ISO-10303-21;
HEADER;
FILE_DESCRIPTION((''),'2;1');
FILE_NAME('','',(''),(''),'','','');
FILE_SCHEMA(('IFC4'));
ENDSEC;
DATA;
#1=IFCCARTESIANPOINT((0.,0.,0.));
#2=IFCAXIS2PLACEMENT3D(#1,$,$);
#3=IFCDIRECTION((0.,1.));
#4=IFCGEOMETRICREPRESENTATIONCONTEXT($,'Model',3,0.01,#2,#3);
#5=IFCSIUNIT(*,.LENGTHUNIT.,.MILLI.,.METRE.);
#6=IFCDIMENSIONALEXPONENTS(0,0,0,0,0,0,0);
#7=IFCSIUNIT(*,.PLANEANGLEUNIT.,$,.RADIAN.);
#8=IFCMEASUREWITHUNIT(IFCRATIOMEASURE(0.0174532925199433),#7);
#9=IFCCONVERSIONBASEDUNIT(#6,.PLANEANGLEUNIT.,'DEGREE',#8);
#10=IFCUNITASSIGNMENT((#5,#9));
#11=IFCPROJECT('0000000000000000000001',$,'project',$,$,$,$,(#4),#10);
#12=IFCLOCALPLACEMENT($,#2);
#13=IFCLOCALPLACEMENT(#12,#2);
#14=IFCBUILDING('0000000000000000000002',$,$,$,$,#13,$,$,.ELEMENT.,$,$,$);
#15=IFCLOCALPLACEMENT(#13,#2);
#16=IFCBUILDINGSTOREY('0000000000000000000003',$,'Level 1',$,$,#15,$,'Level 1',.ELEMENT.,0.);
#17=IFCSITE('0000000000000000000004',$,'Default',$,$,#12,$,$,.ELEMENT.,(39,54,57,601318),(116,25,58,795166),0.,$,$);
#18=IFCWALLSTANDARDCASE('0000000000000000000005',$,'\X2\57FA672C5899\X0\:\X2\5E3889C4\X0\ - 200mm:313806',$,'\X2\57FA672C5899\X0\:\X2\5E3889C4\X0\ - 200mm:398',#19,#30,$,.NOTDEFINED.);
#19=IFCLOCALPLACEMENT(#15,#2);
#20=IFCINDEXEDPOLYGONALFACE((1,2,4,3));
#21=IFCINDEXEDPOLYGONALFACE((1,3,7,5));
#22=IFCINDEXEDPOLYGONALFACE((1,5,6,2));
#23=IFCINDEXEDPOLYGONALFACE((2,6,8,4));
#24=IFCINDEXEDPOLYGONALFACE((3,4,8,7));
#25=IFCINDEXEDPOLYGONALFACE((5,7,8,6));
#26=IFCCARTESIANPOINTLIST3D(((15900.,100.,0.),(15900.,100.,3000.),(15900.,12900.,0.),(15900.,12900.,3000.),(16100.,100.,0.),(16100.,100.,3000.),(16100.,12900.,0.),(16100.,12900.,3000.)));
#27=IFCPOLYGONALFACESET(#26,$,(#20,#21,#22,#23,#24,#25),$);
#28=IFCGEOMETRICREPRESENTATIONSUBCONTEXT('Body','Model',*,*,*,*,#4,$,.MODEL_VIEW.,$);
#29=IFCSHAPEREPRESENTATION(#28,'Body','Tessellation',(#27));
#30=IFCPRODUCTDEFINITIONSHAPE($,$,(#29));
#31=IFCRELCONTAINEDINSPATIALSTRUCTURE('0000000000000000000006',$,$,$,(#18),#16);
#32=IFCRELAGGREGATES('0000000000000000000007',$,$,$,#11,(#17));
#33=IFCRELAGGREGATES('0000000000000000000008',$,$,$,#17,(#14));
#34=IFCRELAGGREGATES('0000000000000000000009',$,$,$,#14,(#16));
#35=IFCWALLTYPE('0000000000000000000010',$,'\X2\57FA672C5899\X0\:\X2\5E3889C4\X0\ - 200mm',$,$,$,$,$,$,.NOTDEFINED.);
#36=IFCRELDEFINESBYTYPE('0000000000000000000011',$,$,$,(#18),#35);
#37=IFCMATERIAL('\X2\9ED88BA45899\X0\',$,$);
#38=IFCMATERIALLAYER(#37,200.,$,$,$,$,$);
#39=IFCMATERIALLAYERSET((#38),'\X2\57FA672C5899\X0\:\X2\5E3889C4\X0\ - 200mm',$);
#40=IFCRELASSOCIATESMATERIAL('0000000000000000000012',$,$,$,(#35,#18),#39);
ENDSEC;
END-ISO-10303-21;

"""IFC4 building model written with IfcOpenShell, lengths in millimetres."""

from ifc_helpers import new_model, entity, si_unit, converted_unit, direction, frame, frame_2d, origin, place, context, subcontext, project, spatial, rectangle, extrude, material, layer, layer_set, layer_usage, type_object, element, save


model = new_model("IFC4")

# Units and contexts
model_context = context("Model", 3, precision=0.01, world=origin(), true_north=direction((0.0, 1.0)))
body_context = subcontext(model_context, "Body", "Model", "MODEL_VIEW")
ifc_project = project(units=[si_unit("LENGTHUNIT", "METRE", prefix="MILLI"), converted_unit("PLANEANGLEUNIT", "DEGREE", entity("IfcRatioMeasure", 0.0174532925199433), si_unit("PLANEANGLEUNIT", "RADIAN"), dimensions=[0, 0, 0, 0, 0, 0, 0])], contexts=[model_context])

# Site, building, storey
site_placement = place(None, origin())
site = spatial("IfcSite", under=ifc_project, at=site_placement, Name="Default", CompositionType="ELEMENT", RefLatitude=(39, 54, 57, 601318), RefLongitude=(116, 25, 58, 795166), RefElevation=0.0)
building_placement = place(site_placement, origin())
building = spatial("IfcBuilding", under=site, at=building_placement, CompositionType="ELEMENT")
storey_placement = place(building_placement, origin())
storey = spatial("IfcBuildingStorey", under=building, at=storey_placement, Name="Level 1", LongName="Level 1", CompositionType="ELEMENT", Elevation=0.0)

# Wall
ifc_material_1 = material(Name="默认墙")
ifc_layer_1 = layer(ifc_material_1, 200.0)
ifc_layer_set_1 = layer_set([ifc_layer_1], Name="基本墙:常规 - 200mm")
wall_type = type_object("IfcWallType", Name="基本墙:常规 - 200mm", PredefinedType="NOTDEFINED", material=ifc_layer_set_1)
ifc_layer_usage_1 = layer_usage(ifc_layer_set_1, "AXIS2", "NEGATIVE", 100.0)
wall_1_placement = place(storey_placement, frame((16000.0, 12900.0, 0.0), z_axis=(0.0, 0.0, 1.0), x_axis=(0.0, -1.0, 0.0)))
element("IfcWallStandardCase", 1, at=wall_1_placement, inside=storey, type_object=wall_type, material=ifc_layer_usage_1, Name="基本墙:常规 - 200mm:313806", ObjectType="基本墙:常规 - 200mm:398", PredefinedType="NOTDEFINED", context=body_context, shape_type="SweptSolid", body=[
    extrude(rectangle(XDim=12800.0, YDim=200.0, at=frame_2d((6400.0, 0.0), x_axis=(-1.0, 0.0))), origin(), (0.0, 0.0, 1.0), 3000.0),
])

save(model, "model.ifc")
